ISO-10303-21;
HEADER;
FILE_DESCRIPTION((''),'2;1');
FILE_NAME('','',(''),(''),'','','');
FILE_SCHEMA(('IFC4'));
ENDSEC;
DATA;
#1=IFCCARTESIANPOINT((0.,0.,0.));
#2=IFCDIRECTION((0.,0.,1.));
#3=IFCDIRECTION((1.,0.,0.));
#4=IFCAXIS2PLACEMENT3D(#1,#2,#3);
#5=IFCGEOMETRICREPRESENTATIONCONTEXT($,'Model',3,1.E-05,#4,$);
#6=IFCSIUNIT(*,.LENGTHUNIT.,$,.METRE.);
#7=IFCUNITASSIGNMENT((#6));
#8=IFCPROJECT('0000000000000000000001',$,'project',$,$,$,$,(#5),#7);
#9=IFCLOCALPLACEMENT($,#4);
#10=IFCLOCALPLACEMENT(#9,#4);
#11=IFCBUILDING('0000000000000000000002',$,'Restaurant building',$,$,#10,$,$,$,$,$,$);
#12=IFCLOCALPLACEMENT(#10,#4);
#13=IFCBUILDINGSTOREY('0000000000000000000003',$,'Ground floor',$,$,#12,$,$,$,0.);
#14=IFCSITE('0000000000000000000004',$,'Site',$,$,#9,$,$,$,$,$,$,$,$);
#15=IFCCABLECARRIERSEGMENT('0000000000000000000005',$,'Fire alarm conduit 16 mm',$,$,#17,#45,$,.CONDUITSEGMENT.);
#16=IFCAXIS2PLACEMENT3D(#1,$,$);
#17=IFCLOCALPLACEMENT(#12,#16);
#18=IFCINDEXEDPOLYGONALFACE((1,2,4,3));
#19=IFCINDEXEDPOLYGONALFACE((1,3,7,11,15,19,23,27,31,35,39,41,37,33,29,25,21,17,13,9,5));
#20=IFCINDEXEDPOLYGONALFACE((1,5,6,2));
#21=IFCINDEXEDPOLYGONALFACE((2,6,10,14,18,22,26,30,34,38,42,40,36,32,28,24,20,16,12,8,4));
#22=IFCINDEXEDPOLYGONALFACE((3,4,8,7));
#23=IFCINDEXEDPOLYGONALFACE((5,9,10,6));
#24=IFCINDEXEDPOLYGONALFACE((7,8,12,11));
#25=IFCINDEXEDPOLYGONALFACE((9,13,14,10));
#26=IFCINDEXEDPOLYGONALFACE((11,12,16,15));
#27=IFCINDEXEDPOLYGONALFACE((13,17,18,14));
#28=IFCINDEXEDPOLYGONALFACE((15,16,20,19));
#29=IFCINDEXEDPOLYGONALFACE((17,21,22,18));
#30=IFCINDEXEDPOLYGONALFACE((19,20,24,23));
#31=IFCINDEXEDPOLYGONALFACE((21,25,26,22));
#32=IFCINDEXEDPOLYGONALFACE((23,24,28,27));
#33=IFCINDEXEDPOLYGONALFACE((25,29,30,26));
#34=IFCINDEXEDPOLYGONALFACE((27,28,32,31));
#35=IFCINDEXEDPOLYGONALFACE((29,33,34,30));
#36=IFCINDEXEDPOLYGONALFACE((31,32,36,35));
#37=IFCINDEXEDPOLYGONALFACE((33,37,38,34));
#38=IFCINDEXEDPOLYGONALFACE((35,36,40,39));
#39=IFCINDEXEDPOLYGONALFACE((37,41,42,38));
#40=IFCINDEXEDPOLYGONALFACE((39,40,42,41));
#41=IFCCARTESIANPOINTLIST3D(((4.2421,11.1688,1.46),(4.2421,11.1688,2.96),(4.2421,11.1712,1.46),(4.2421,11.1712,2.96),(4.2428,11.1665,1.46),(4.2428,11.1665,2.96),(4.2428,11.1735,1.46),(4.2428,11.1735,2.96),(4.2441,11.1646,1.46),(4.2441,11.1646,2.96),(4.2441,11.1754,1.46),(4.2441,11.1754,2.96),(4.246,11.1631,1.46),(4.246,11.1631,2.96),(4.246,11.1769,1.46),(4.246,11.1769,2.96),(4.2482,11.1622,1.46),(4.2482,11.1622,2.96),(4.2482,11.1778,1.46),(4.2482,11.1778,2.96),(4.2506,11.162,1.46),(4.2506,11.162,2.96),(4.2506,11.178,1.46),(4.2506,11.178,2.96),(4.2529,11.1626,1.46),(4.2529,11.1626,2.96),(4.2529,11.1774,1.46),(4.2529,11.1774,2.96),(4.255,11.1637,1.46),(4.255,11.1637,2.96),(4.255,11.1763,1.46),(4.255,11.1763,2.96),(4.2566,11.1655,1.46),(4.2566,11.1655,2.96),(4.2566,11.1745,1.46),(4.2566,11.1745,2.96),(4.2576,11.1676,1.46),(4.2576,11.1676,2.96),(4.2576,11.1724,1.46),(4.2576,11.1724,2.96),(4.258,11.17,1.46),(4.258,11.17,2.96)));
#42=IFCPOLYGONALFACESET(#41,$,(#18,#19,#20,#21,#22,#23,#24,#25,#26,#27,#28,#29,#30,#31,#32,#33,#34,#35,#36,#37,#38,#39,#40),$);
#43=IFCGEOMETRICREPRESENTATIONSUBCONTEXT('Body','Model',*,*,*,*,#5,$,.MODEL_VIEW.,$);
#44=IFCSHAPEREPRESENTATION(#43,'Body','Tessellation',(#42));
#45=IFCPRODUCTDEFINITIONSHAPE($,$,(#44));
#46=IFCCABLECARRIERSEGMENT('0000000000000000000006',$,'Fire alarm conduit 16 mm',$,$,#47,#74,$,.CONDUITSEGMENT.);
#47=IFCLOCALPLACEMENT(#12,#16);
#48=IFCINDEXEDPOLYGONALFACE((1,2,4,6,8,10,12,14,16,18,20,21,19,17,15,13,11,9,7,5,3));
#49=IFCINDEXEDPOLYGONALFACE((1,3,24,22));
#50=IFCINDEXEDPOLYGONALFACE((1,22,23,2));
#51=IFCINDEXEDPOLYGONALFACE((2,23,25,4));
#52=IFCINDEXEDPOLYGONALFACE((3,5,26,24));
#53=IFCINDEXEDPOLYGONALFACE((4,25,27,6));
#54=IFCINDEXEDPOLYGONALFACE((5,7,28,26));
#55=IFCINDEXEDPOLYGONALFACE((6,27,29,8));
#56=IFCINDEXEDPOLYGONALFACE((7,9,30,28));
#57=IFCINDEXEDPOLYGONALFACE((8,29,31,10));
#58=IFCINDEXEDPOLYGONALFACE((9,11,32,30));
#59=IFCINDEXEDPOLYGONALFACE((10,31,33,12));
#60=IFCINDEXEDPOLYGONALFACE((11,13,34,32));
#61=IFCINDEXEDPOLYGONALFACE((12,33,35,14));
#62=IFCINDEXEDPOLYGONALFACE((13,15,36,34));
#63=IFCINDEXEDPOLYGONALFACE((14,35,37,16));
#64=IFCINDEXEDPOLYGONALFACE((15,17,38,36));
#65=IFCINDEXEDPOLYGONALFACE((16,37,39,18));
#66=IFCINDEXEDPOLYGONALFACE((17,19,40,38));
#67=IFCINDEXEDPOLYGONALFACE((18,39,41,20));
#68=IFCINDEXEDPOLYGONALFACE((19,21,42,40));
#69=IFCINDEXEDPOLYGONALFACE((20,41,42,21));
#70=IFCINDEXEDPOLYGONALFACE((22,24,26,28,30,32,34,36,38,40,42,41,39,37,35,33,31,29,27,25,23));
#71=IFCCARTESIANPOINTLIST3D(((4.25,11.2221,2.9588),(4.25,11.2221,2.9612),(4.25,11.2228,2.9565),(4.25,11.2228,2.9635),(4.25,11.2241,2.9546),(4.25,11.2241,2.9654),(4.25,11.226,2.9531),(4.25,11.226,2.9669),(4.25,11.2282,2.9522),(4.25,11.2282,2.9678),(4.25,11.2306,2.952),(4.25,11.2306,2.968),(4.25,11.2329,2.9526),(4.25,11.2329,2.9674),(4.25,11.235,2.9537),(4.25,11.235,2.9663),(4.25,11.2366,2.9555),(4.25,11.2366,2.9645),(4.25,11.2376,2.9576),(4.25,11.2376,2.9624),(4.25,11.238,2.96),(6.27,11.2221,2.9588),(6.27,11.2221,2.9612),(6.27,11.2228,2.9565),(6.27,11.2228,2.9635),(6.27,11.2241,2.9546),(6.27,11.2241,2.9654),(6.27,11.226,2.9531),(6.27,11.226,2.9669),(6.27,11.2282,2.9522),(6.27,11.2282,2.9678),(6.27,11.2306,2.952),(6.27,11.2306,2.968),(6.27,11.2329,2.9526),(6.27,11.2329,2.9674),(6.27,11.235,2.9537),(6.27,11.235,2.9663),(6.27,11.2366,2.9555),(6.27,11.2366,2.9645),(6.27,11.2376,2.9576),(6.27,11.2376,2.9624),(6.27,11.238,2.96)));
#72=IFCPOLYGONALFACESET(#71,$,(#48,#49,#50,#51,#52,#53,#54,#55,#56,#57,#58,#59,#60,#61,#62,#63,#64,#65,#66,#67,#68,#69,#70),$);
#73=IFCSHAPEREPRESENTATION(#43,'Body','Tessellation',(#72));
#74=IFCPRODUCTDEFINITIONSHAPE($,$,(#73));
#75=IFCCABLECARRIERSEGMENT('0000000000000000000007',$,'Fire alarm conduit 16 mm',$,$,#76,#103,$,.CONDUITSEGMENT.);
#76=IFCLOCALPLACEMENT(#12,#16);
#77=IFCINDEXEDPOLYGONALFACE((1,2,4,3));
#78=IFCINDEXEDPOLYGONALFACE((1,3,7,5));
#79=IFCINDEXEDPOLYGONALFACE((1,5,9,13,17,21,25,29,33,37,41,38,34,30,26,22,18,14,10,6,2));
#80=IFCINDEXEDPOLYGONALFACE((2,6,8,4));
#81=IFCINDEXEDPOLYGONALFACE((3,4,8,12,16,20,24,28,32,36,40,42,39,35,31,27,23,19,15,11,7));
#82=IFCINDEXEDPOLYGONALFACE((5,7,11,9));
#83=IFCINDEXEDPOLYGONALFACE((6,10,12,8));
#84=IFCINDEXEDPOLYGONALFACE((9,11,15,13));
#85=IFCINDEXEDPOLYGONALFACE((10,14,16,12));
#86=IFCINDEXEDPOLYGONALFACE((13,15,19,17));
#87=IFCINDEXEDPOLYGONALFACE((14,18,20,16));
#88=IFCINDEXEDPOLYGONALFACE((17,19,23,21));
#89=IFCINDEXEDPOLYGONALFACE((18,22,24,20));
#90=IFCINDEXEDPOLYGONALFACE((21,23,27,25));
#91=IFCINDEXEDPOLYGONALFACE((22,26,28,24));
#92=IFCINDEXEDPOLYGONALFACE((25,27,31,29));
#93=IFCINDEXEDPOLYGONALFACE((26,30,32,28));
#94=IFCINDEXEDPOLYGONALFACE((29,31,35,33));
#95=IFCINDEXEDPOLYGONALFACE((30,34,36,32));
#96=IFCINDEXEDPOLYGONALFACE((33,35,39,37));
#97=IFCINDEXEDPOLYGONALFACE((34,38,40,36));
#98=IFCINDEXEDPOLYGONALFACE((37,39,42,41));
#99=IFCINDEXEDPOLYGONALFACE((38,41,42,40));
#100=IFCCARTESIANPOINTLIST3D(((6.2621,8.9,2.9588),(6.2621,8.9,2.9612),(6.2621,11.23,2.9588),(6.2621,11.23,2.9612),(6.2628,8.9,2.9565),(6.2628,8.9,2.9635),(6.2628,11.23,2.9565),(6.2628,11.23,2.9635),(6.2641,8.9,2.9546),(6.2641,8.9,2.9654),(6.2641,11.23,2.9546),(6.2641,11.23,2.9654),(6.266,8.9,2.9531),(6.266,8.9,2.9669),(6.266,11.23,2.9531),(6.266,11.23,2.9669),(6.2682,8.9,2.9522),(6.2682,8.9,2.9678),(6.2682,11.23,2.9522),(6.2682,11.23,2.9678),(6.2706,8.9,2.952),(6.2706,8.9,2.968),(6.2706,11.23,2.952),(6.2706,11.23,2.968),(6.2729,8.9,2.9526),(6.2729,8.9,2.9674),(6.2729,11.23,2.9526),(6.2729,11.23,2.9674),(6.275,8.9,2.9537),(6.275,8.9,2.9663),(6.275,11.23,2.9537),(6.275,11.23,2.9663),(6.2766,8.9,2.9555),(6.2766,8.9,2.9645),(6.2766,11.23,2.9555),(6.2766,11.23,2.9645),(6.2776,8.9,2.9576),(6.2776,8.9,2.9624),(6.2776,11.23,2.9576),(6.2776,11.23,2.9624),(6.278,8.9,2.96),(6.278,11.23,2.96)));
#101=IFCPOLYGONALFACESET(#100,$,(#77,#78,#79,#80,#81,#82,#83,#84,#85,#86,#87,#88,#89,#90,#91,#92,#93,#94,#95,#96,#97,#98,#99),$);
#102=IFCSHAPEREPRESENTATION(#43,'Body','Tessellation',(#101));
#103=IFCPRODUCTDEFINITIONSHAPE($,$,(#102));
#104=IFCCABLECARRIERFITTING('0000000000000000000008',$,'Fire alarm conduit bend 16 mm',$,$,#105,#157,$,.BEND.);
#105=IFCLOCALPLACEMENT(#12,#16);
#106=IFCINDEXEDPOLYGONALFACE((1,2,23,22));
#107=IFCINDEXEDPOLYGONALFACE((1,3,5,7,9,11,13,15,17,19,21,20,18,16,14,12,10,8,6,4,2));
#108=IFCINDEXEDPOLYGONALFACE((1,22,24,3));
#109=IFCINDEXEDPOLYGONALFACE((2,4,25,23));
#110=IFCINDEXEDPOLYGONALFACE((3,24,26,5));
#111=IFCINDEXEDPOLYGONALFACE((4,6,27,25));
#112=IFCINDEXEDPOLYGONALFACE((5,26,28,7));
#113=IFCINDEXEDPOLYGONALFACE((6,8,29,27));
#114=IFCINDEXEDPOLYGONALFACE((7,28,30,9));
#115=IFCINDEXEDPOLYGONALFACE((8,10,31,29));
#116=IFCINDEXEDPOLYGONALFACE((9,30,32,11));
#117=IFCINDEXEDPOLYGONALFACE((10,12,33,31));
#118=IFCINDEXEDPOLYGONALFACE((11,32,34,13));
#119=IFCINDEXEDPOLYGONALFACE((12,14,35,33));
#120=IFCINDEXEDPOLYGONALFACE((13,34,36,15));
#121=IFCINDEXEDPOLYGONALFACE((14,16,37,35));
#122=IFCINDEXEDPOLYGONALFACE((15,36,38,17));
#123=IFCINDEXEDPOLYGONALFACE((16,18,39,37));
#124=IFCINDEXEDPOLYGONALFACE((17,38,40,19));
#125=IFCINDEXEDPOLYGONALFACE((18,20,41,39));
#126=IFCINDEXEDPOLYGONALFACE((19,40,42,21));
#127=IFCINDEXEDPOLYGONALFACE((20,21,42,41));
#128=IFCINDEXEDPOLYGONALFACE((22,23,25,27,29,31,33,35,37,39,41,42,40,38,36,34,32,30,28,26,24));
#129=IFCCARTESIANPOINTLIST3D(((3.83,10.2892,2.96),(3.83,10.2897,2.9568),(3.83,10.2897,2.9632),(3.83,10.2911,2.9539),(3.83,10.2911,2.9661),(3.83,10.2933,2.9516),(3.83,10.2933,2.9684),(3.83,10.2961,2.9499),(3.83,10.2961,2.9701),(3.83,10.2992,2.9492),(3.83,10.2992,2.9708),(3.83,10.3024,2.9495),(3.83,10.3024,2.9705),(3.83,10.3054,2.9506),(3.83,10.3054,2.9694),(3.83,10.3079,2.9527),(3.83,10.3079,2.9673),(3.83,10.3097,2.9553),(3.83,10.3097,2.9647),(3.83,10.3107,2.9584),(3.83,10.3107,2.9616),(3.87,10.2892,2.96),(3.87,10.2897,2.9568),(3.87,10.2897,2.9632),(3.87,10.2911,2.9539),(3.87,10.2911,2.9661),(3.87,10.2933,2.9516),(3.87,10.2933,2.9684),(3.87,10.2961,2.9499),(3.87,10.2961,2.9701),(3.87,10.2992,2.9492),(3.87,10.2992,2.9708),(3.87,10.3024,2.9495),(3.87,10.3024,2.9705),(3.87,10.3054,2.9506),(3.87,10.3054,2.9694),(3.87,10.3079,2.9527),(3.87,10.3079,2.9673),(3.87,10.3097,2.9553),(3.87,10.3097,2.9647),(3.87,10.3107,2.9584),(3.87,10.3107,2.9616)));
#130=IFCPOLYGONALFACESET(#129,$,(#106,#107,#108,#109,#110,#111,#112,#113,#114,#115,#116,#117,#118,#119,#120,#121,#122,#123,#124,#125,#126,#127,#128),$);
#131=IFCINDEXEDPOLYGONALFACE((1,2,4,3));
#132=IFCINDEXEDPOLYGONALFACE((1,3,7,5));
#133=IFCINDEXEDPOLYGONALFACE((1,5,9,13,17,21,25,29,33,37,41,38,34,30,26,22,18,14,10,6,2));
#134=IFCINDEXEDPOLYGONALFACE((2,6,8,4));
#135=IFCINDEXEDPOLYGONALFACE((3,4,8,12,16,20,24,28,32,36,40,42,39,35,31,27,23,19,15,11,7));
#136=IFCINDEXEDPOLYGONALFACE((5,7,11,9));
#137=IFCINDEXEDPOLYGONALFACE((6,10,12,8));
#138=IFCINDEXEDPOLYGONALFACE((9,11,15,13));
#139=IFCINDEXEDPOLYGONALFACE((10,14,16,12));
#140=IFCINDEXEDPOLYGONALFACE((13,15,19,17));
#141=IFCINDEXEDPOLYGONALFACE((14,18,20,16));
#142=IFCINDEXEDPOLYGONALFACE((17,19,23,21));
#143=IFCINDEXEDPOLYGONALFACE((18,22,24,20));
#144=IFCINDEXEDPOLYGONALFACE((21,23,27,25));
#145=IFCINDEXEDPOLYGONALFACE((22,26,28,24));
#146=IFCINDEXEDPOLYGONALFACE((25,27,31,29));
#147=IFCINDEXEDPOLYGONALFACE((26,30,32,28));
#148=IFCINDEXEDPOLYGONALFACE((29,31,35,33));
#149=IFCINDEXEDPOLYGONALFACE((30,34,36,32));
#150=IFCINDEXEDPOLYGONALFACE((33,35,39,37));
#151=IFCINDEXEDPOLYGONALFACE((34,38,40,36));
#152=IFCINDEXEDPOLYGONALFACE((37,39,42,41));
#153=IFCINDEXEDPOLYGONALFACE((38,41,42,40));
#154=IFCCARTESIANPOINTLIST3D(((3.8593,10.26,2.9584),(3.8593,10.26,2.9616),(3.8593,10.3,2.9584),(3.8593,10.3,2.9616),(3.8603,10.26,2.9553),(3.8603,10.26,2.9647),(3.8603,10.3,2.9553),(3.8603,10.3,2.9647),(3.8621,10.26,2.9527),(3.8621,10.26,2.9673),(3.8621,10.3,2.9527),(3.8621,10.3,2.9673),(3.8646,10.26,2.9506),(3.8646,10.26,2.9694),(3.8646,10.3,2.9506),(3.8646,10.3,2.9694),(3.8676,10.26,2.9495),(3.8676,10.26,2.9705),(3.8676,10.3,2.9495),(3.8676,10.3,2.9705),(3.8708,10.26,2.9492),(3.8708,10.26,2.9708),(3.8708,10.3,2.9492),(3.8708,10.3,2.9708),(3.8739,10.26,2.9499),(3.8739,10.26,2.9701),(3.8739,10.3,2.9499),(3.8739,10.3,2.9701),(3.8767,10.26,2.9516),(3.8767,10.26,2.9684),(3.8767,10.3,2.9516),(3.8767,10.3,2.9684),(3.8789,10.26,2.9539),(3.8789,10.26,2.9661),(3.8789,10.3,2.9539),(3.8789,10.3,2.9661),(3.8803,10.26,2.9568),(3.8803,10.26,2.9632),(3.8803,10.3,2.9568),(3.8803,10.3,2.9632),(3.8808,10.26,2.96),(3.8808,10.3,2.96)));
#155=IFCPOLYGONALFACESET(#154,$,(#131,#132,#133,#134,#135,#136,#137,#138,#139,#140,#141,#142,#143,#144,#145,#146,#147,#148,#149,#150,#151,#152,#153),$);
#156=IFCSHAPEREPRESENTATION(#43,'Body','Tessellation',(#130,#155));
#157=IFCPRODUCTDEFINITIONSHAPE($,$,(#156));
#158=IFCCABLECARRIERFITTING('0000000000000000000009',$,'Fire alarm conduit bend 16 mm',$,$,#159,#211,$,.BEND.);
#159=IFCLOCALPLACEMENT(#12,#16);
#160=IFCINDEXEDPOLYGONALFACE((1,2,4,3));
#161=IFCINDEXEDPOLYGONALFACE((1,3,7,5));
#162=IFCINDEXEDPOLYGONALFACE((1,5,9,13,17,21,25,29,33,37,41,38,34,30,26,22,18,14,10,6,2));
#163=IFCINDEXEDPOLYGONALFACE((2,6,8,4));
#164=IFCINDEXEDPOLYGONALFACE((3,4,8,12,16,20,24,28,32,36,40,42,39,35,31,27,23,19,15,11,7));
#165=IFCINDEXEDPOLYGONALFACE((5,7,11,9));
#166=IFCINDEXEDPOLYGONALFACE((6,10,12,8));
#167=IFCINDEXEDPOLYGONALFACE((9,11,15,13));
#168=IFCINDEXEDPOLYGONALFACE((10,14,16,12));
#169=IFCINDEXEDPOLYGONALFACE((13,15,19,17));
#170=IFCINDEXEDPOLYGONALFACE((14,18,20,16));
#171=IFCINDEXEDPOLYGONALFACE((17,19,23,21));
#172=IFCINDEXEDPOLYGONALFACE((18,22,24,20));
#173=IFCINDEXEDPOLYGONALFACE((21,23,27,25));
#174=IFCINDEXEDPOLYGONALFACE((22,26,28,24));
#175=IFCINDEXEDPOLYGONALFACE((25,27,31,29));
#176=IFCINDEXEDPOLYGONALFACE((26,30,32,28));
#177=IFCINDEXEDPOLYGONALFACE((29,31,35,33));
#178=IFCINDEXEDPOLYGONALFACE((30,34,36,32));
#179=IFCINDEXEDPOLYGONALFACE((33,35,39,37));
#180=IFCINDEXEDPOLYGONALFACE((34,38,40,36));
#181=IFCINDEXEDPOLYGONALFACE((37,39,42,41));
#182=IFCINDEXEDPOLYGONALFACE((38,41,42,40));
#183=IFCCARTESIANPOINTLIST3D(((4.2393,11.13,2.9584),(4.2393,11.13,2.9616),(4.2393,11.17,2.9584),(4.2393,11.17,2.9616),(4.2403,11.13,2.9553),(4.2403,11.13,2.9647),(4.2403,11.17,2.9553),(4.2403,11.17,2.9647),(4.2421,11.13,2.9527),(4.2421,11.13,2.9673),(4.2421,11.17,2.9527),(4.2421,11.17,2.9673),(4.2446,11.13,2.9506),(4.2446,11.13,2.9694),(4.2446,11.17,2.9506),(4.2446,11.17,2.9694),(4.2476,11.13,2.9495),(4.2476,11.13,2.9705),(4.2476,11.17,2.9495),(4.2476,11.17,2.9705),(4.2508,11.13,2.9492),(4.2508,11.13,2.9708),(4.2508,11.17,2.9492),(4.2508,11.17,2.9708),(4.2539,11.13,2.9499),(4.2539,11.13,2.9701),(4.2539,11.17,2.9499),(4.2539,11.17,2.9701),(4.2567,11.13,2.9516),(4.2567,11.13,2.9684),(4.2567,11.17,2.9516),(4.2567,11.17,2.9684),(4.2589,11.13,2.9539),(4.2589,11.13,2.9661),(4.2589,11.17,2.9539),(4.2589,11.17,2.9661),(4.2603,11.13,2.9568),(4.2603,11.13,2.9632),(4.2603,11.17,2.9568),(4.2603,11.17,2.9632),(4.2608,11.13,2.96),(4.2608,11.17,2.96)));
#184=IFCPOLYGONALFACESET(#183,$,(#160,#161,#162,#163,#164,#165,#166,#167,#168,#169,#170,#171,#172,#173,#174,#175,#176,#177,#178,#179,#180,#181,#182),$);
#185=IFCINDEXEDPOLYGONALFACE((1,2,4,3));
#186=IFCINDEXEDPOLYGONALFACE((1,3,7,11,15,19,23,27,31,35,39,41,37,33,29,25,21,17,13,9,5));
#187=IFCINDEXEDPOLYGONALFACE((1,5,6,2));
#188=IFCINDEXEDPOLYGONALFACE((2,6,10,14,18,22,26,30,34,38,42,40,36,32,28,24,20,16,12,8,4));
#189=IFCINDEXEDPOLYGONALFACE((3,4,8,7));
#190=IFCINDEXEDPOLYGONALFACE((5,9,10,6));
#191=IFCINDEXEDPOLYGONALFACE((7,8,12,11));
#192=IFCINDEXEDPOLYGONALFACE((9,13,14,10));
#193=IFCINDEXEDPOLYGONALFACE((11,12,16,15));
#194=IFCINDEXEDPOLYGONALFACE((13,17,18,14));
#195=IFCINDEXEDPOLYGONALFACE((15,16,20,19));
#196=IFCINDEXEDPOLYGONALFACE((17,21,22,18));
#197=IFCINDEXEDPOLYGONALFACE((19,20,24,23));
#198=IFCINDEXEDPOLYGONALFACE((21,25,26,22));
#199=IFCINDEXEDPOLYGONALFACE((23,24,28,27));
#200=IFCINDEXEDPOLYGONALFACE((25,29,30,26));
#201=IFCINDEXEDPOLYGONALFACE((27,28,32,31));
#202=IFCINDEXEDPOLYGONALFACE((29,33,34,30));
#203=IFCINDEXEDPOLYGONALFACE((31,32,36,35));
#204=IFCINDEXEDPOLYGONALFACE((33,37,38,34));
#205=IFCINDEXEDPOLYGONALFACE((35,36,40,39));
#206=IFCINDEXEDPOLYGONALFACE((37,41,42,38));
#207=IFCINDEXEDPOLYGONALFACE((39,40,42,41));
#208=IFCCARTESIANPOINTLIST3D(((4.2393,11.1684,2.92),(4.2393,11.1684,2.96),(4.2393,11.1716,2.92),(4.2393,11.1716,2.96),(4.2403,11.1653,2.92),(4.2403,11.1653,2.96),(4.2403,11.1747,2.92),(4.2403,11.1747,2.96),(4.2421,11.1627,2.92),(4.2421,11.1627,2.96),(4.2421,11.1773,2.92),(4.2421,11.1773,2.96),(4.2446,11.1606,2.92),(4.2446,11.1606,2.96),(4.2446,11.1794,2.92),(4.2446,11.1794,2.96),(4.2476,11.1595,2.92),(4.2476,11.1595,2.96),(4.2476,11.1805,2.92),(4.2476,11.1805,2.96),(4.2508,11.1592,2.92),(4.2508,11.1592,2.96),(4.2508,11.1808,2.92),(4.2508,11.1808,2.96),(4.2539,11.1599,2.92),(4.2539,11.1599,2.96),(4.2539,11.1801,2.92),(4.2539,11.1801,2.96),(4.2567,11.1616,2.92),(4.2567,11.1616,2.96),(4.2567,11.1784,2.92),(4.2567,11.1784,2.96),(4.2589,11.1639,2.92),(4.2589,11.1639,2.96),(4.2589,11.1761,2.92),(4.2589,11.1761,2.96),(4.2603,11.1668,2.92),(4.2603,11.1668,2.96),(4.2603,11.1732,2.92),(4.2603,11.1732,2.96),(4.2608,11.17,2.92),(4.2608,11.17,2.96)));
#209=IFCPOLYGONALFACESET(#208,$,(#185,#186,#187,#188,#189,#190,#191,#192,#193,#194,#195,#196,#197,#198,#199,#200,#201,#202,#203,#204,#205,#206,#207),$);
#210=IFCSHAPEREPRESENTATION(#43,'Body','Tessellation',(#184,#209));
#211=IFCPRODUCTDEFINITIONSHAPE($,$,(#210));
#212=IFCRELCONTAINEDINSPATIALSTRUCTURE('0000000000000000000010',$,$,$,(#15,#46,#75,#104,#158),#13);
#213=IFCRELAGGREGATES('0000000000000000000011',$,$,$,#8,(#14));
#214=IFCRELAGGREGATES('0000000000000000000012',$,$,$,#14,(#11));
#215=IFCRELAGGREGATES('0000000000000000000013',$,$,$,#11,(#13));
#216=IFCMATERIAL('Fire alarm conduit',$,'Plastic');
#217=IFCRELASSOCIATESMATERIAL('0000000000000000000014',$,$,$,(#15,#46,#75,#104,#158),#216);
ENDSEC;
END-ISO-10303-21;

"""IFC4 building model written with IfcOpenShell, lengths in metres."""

from ifc_helpers import new_model, si_unit, frame, origin_with_axes, origin_2d, place, context, subcontext, project, spatial, circle, extrude, material, element, save


model = new_model("IFC4")

# Units and contexts
model_context = context("Model", 3, precision=1e-05, world=origin_with_axes())
body_context = subcontext(model_context, "Body", "Model", "MODEL_VIEW")
ifc_project = project(units=[si_unit("LENGTHUNIT", "METRE")], contexts=[model_context])

# Site, building, storey
site_placement = place(None, origin_with_axes())
site = spatial("IfcSite", under=ifc_project, at=site_placement, Name="Site")
building_placement = place(site_placement, origin_with_axes())
building = spatial("IfcBuilding", under=site, at=building_placement, Name="Restaurant building")
storey_placement = place(building_placement, origin_with_axes())
storey = spatial("IfcBuildingStorey", under=building, at=storey_placement, Name="Ground floor", Elevation=0.0)

# Cable carrier segments
ifc_material_1 = material(Name="Fire alarm conduit", Category="Plastic")
cable_carrier_segment_1_placement = place(storey_placement, frame((4.25, 11.17, 2.96)))
element("IfcCableCarrierSegment", 1, at=cable_carrier_segment_1_placement, inside=storey, material=ifc_material_1, Name="Fire alarm conduit 16 mm", PredefinedType="CONDUITSEGMENT", context=body_context, shape_type="SweptSolid", body=[
    extrude(circle(Radius=0.008, at=origin_2d()), frame((0.0, 0.0, 0.0), z_axis=(0.0, 0.0, -1.0), x_axis=(1.0, 0.0, 0.0)), (0.0, 0.0, 1.0), 1.5),
])
cable_carrier_segment_2_placement = place(storey_placement, frame((4.25, 11.23, 2.96)))
element("IfcCableCarrierSegment", 2, at=cable_carrier_segment_2_placement, inside=storey, material=ifc_material_1, Name="Fire alarm conduit 16 mm", PredefinedType="CONDUITSEGMENT", context=body_context, shape_type="SweptSolid", body=[
    extrude(circle(Radius=0.008, at=origin_2d()), frame((0.0, 0.0, 0.0), z_axis=(1.0, 0.0, 0.0), x_axis=(0.0, 1.0, 0.0)), (0.0, 0.0, 1.0), 2.02),
])
cable_carrier_segment_3_placement = place(storey_placement, frame((6.27, 11.23, 2.96)))
element("IfcCableCarrierSegment", 3, at=cable_carrier_segment_3_placement, inside=storey, material=ifc_material_1, Name="Fire alarm conduit 16 mm", PredefinedType="CONDUITSEGMENT", context=body_context, shape_type="SweptSolid", body=[
    extrude(circle(Radius=0.008, at=origin_2d()), frame((0.0, 0.0, 0.0), z_axis=(0.0, -1.0, 0.0), x_axis=(1.0, 0.0, 0.0)), (0.0, 0.0, 1.0), 2.33),
])

# Cable carrier fittings
cable_carrier_fitting_1_placement = place(storey_placement, frame((3.87, 10.3, 2.96)))
element("IfcCableCarrierFitting", 4, at=cable_carrier_fitting_1_placement, inside=storey, material=ifc_material_1, Name="Fire alarm conduit bend 16 mm", PredefinedType="BEND", context=body_context, shape_type="SweptSolid", body=[
    extrude(circle(Radius=0.0108, at=origin_2d()), frame((0.0, 0.0, 0.0), z_axis=(-1.0, 0.0, 0.0), x_axis=(0.0, -1.0, 0.0)), (0.0, 0.0, 1.0), 0.04),
    extrude(circle(Radius=0.0108, at=origin_2d()), frame((0.0, 0.0, 0.0), z_axis=(0.0, -1.0, 0.0), x_axis=(1.0, 0.0, 0.0)), (0.0, 0.0, 1.0), 0.04),
])
cable_carrier_fitting_2_placement = place(storey_placement, frame((4.25, 11.17, 2.96)))
element("IfcCableCarrierFitting", 5, at=cable_carrier_fitting_2_placement, inside=storey, material=ifc_material_1, Name="Fire alarm conduit bend 16 mm", PredefinedType="BEND", context=body_context, shape_type="SweptSolid", body=[
    extrude(circle(Radius=0.0108, at=origin_2d()), frame((0.0, 0.0, 0.0), z_axis=(0.0, -1.0, 0.0), x_axis=(1.0, 0.0, 0.0)), (0.0, 0.0, 1.0), 0.04),
    extrude(circle(Radius=0.0108, at=origin_2d()), frame((0.0, 0.0, 0.0), z_axis=(0.0, 0.0, -1.0), x_axis=(1.0, 0.0, 0.0)), (0.0, 0.0, 1.0), 0.04),
])

save(model, "model.ifc")
